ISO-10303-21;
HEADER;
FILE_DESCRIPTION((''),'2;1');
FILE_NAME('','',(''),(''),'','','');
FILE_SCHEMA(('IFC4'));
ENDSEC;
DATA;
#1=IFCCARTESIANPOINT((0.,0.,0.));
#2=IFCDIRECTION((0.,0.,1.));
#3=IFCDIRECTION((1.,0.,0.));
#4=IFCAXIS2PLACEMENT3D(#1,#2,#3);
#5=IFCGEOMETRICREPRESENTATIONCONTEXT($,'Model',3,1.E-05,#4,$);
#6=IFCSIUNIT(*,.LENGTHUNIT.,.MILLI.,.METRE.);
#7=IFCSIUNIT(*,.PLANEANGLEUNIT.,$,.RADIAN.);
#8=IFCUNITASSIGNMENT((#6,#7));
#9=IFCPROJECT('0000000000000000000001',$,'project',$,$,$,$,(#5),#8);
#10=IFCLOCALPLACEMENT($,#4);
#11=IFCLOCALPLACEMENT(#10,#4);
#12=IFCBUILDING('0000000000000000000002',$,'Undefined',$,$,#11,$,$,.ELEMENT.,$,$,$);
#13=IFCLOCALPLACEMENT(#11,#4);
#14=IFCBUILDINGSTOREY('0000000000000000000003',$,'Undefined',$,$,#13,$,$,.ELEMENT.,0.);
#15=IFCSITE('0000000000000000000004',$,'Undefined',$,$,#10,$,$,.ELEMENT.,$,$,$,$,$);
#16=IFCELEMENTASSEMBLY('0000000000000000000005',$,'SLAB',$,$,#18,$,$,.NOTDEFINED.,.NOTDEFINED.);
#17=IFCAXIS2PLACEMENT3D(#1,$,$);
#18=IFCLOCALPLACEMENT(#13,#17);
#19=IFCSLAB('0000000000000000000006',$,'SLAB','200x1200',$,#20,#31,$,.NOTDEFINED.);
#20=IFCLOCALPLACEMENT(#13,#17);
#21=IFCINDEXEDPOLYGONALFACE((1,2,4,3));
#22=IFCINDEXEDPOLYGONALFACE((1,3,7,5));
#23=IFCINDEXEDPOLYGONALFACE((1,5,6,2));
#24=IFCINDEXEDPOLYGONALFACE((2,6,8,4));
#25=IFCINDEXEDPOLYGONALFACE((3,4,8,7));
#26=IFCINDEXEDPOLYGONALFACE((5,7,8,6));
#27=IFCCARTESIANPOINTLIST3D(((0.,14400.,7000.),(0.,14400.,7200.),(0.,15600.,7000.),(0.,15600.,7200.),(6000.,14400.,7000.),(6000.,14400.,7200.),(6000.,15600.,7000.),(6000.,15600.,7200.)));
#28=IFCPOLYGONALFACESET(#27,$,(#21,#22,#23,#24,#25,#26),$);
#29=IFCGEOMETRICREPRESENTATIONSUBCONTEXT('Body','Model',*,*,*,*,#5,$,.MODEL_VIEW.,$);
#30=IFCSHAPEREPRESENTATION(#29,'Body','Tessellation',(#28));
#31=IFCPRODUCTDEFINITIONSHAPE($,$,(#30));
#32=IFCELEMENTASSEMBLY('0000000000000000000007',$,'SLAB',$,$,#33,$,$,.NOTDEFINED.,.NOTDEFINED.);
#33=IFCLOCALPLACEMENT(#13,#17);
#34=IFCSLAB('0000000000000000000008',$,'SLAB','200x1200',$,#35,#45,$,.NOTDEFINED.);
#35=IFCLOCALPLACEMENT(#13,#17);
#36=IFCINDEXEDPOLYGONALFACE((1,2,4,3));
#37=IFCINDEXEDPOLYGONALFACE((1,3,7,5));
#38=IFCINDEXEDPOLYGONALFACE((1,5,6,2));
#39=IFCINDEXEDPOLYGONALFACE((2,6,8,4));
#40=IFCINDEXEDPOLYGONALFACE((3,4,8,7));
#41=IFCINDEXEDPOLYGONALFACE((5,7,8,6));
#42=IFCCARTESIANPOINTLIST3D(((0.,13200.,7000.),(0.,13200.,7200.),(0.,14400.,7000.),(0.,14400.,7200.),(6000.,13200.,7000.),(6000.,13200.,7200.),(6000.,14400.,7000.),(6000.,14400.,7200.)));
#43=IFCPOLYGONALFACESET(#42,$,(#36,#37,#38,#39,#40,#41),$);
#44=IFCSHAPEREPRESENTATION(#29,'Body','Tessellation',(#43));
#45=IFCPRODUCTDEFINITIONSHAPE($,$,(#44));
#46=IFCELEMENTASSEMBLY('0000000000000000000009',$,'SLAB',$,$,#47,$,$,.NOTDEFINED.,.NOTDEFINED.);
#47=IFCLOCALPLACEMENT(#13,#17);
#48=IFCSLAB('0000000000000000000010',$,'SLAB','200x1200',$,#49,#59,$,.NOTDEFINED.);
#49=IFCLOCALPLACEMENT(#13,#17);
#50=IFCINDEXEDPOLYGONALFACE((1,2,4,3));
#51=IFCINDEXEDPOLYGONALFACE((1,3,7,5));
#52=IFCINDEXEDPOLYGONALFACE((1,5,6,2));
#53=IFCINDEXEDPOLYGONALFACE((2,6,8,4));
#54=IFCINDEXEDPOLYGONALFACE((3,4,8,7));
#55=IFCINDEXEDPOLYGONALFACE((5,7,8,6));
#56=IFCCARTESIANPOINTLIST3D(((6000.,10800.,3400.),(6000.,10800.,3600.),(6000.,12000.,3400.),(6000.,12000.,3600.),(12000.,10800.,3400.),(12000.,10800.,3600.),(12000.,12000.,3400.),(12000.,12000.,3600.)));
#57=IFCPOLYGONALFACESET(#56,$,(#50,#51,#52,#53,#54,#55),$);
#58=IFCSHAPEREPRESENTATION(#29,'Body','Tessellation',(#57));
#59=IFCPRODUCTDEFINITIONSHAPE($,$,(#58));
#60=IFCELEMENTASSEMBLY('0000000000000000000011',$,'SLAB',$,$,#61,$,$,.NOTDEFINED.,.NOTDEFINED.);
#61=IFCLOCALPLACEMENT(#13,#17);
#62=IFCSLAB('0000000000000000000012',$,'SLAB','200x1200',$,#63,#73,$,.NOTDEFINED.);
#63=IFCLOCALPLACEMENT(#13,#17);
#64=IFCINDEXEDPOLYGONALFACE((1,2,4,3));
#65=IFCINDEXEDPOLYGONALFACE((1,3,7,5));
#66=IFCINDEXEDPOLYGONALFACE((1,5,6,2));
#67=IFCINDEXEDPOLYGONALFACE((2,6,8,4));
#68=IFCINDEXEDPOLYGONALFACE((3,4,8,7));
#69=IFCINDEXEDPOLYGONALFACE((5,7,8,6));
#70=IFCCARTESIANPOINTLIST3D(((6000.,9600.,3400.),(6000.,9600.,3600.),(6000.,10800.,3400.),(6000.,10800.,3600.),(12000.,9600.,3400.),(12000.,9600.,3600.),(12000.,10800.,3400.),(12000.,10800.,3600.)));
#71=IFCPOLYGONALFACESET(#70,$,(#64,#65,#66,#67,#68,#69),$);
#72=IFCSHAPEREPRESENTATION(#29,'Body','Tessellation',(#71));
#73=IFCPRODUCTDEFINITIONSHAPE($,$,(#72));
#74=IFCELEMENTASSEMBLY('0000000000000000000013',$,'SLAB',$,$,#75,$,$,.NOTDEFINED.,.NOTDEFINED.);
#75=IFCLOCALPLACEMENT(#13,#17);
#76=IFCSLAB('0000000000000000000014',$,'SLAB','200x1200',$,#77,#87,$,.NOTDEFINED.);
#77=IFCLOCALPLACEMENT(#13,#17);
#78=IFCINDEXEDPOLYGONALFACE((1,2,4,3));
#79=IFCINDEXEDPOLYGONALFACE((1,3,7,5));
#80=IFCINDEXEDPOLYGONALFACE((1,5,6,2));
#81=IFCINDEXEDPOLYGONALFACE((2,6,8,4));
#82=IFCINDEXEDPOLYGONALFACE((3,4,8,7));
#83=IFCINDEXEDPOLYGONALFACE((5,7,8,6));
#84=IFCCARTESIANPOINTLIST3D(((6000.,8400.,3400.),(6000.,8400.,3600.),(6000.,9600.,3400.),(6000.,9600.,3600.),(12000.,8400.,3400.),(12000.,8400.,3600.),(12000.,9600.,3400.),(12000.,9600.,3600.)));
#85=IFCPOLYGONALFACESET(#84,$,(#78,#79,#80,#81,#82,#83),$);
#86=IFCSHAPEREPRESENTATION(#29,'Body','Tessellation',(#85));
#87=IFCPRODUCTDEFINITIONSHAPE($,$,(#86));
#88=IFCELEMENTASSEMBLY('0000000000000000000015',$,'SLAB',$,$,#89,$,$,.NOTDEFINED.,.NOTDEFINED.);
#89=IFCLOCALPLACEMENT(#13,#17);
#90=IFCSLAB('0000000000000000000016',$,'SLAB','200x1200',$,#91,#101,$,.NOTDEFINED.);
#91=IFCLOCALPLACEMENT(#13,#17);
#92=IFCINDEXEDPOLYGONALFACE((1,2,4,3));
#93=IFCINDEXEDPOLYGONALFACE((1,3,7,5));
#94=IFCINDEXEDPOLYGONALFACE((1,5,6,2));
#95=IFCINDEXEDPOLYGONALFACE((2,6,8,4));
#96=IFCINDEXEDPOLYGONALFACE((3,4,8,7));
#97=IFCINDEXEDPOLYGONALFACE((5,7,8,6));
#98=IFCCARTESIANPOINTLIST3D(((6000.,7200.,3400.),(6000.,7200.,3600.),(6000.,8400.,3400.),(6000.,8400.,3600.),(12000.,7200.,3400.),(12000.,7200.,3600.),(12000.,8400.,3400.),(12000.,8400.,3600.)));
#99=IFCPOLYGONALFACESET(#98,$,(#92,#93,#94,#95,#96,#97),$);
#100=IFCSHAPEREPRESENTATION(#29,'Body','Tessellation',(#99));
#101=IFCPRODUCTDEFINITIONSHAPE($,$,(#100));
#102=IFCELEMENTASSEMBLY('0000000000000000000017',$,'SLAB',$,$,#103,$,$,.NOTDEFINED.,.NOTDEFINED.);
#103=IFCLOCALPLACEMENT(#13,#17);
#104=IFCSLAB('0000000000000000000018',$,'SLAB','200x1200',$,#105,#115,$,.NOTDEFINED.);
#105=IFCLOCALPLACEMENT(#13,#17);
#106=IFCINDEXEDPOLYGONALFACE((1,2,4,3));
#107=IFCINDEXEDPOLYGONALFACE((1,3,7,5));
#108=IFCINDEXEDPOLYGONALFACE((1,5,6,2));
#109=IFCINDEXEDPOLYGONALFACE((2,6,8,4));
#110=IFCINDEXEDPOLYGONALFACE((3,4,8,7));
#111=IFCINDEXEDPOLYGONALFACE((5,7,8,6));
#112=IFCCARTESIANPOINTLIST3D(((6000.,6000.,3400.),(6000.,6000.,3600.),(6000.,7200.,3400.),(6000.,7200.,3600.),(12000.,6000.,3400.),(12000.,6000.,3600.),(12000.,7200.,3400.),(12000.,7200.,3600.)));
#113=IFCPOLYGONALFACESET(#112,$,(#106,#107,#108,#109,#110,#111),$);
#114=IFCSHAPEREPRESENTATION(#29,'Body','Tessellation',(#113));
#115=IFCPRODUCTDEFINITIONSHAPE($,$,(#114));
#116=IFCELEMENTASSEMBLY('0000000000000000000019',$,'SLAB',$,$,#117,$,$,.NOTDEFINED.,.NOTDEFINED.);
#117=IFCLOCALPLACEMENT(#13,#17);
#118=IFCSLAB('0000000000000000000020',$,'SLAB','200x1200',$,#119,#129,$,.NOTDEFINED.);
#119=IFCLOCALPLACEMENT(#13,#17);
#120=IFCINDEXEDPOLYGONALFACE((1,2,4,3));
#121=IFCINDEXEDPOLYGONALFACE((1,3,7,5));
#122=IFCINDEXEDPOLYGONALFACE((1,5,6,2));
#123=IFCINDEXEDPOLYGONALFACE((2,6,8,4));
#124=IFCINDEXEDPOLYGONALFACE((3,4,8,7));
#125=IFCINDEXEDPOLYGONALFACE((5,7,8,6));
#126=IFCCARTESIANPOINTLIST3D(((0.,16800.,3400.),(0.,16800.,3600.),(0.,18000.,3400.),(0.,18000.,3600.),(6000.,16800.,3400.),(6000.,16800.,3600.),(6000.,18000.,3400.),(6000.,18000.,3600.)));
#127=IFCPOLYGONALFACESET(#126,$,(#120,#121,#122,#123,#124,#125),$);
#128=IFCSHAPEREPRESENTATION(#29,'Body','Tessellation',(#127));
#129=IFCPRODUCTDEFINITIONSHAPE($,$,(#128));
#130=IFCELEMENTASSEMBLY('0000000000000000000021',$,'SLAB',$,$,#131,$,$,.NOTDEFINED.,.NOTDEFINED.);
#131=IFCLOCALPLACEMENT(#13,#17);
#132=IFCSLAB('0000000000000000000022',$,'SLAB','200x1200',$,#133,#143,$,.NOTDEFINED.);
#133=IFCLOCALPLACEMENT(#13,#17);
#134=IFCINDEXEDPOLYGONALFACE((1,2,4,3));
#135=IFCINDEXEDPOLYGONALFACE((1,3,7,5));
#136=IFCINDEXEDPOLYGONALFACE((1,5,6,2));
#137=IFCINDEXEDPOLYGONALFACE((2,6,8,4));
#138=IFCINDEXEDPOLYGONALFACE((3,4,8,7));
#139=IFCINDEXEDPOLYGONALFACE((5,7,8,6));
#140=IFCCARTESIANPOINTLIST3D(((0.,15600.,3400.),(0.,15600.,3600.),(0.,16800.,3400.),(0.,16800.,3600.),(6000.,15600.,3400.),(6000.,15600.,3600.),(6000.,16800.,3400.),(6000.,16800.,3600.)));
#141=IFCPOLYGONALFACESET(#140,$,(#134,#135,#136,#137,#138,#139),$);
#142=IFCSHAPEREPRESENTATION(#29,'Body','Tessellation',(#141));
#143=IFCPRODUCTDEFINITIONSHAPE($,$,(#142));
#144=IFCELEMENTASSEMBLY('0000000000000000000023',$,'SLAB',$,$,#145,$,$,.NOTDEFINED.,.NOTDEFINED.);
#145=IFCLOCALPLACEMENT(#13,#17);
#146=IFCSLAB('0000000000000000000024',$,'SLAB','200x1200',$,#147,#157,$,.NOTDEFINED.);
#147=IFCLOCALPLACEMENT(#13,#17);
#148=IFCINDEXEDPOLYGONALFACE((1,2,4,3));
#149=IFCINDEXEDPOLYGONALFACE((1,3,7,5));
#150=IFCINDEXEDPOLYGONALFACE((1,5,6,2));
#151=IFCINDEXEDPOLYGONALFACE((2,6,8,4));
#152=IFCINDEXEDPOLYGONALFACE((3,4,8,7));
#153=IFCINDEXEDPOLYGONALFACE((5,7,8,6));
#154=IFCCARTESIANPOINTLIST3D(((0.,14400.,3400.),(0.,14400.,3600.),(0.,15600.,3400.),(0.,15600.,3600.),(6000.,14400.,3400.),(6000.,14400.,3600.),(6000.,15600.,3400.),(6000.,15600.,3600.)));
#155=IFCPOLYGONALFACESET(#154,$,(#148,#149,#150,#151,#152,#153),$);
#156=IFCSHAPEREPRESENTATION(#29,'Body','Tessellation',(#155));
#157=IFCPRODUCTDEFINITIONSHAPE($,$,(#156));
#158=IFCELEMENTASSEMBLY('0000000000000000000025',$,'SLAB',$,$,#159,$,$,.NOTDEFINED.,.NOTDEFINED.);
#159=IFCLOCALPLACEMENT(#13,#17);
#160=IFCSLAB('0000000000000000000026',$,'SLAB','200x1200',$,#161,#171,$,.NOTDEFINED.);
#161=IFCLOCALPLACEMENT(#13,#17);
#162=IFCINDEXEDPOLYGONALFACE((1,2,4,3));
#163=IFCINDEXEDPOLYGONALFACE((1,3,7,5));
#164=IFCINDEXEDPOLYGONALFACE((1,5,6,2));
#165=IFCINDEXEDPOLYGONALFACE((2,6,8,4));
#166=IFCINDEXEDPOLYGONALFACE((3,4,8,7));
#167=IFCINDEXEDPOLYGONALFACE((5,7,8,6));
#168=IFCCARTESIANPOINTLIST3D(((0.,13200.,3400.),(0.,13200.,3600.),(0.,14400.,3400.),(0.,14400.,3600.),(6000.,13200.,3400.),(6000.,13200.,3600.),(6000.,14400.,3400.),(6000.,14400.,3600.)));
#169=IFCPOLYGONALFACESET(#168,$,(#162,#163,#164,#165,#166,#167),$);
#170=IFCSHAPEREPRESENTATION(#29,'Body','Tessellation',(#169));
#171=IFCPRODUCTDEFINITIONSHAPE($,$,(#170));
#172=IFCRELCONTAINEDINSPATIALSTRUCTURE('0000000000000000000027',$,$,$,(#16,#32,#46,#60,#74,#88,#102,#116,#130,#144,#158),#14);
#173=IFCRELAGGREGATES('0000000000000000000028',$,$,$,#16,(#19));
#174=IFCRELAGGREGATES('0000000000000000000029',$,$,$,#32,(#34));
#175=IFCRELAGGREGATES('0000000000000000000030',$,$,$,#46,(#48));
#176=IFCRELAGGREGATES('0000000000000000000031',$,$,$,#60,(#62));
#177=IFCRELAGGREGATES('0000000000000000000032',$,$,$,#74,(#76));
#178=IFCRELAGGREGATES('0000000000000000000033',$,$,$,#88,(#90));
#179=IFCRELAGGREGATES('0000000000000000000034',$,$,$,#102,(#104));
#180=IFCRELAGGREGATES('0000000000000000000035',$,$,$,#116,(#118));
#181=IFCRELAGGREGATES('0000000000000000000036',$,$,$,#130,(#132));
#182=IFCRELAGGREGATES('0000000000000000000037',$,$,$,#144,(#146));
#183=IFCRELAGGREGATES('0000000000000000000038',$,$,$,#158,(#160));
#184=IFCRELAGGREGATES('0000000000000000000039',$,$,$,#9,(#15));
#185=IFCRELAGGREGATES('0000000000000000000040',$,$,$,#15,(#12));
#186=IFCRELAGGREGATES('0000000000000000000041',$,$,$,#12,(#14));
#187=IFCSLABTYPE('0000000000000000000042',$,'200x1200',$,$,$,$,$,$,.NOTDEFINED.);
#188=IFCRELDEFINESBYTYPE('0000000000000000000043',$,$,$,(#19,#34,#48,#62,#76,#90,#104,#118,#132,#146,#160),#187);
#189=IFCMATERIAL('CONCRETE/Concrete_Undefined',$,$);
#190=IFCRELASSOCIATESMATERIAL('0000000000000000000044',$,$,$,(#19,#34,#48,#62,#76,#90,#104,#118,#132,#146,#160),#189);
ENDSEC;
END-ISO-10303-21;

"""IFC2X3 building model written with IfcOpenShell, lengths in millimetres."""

from ifc_helpers import new_model, si_unit, frame, origin_with_axes, place, context, subcontext, project, spatial, polyline, outline, extrude, material, type_object, element, aggregate, save


model = new_model("IFC2X3")

# Units and contexts
model_context = context("Model", 3, precision=1e-05, world=origin_with_axes())
body_context = subcontext(model_context, "Body", "Model", "MODEL_VIEW")
ifc_project = project(units=[si_unit("LENGTHUNIT", "METRE", prefix="MILLI"), si_unit("PLANEANGLEUNIT", "RADIAN")], contexts=[model_context])

# Site, building, storey
site_placement = place(None, origin_with_axes())
site = spatial("IfcSite", under=ifc_project, at=site_placement, Name="Undefined", CompositionType="ELEMENT")
building_placement = place(site_placement, origin_with_axes())
building = spatial("IfcBuilding", under=site, at=building_placement, Name="Undefined", CompositionType="ELEMENT")
storey_placement = place(building_placement, origin_with_axes())
storey = spatial("IfcBuildingStorey", under=building, at=storey_placement, Name="Undefined", CompositionType="ELEMENT", Elevation=0.0)

# Shared definitions
ifc_material_1 = material(Name="CONCRETE/Concrete_Undefined")

# Element assemblies, slabs
slab_type = type_object("IfcSlabType", Name="200x1200", PredefinedType="NOTDEFINED")
assembly_1_placement = place(storey_placement, origin_with_axes())
assembly_1 = element("IfcElementAssembly", 1, at=assembly_1_placement, inside=storey, Name="SLAB", AssemblyPlace="NOTDEFINED", PredefinedType="NOTDEFINED")
slab_1_placement = place(assembly_1_placement, frame((6000.0, 14400.0, 7100.0), z_axis=(0.0, 0.0, 1.0), x_axis=(0.0, 1.0, 0.0)))
slab_1 = element("IfcSlab", 2, at=slab_1_placement, type_object=slab_type, material=ifc_material_1, Name="SLAB", Description="200x1200", PredefinedType="NOTDEFINED", context=body_context, shape_type="SweptSolid", body=[
    extrude(outline(polyline([(0.0, 0.0), (1200.0, 0.0), (1200.0, 6000.0), (0.0, 6000.0), (0.0, 0.0)])), frame((0.0, 0.0, -100.0), z_axis=(0.0, 0.0, 1.0), x_axis=(1.0, 0.0, 0.0)), (0.0, 0.0, 1.0), 200.0),
])
aggregate(assembly_1, [slab_1])
assembly_2_placement = place(storey_placement, origin_with_axes())
assembly_2 = element("IfcElementAssembly", 3, at=assembly_2_placement, inside=storey, Name="SLAB", AssemblyPlace="NOTDEFINED", PredefinedType="NOTDEFINED")
slab_2_placement = place(assembly_2_placement, frame((6000.0, 13200.0, 7100.0), z_axis=(0.0, 0.0, 1.0), x_axis=(0.0, 1.0, 0.0)))
slab_2 = element("IfcSlab", 4, at=slab_2_placement, type_object=slab_type, material=ifc_material_1, Name="SLAB", Description="200x1200", PredefinedType="NOTDEFINED", context=body_context, shape_type="SweptSolid", body=[
    extrude(outline(polyline([(0.0, 0.0), (1200.0, 0.0), (1200.0, 6000.0), (0.0, 6000.0), (0.0, 0.0)])), frame((0.0, 0.0, -100.0), z_axis=(0.0, 0.0, 1.0), x_axis=(1.0, 0.0, 0.0)), (0.0, 0.0, 1.0), 200.0),
])
aggregate(assembly_2, [slab_2])
assembly_3_placement = place(storey_placement, origin_with_axes())
assembly_3 = element("IfcElementAssembly", 5, at=assembly_3_placement, inside=storey, Name="SLAB", AssemblyPlace="NOTDEFINED", PredefinedType="NOTDEFINED")
slab_3_placement = place(assembly_3_placement, frame((12000.0, 10800.0, 3500.0), z_axis=(0.0, 0.0, 1.0), x_axis=(0.0, 1.0, 0.0)))
slab_3 = element("IfcSlab", 6, at=slab_3_placement, type_object=slab_type, material=ifc_material_1, Name="SLAB", Description="200x1200", PredefinedType="NOTDEFINED", context=body_context, shape_type="SweptSolid", body=[
    extrude(outline(polyline([(0.0, 0.0), (1200.0, 0.0), (1200.0, 6000.0), (0.0, 6000.0), (0.0, 0.0)])), frame((0.0, 0.0, -100.0), z_axis=(0.0, 0.0, 1.0), x_axis=(1.0, 0.0, 0.0)), (0.0, 0.0, 1.0), 200.0),
])
aggregate(assembly_3, [slab_3])
assembly_4_placement = place(storey_placement, origin_with_axes())
assembly_4 = element("IfcElementAssembly", 7, at=assembly_4_placement, inside=storey, Name="SLAB", AssemblyPlace="NOTDEFINED", PredefinedType="NOTDEFINED")
slab_4_placement = place(assembly_4_placement, frame((12000.0, 9600.0, 3500.0), z_axis=(0.0, 0.0, 1.0), x_axis=(0.0, 1.0, 0.0)))
slab_4 = element("IfcSlab", 8, at=slab_4_placement, type_object=slab_type, material=ifc_material_1, Name="SLAB", Description="200x1200", PredefinedType="NOTDEFINED", context=body_context, shape_type="SweptSolid", body=[
    extrude(outline(polyline([(0.0, 0.0), (1200.0, 0.0), (1200.0, 6000.0), (0.0, 6000.0), (0.0, 0.0)])), frame((0.0, 0.0, -100.0), z_axis=(0.0, 0.0, 1.0), x_axis=(1.0, 0.0, 0.0)), (0.0, 0.0, 1.0), 200.0),
])
aggregate(assembly_4, [slab_4])
assembly_5_placement = place(storey_placement, origin_with_axes())
assembly_5 = element("IfcElementAssembly", 9, at=assembly_5_placement, inside=storey, Name="SLAB", AssemblyPlace="NOTDEFINED", PredefinedType="NOTDEFINED")
slab_5_placement = place(assembly_5_placement, frame((12000.0, 8400.0, 3500.0), z_axis=(0.0, 0.0, 1.0), x_axis=(0.0, 1.0, 0.0)))
slab_5 = element("IfcSlab", 10, at=slab_5_placement, type_object=slab_type, material=ifc_material_1, Name="SLAB", Description="200x1200", PredefinedType="NOTDEFINED", context=body_context, shape_type="SweptSolid", body=[
    extrude(outline(polyline([(0.0, 0.0), (1200.0, 0.0), (1200.0, 6000.0), (0.0, 6000.0), (0.0, 0.0)])), frame((0.0, 0.0, -100.0), z_axis=(0.0, 0.0, 1.0), x_axis=(1.0, 0.0, 0.0)), (0.0, 0.0, 1.0), 200.0),
])
aggregate(assembly_5, [slab_5])
assembly_6_placement = place(storey_placement, origin_with_axes())
assembly_6 = element("IfcElementAssembly", 11, at=assembly_6_placement, inside=storey, Name="SLAB", AssemblyPlace="NOTDEFINED", PredefinedType="NOTDEFINED")
slab_6_placement = place(assembly_6_placement, frame((12000.0, 7200.0, 3500.0), z_axis=(0.0, 0.0, 1.0), x_axis=(0.0, 1.0, 0.0)))
slab_6 = element("IfcSlab", 12, at=slab_6_placement, type_object=slab_type, material=ifc_material_1, Name="SLAB", Description="200x1200", PredefinedType="NOTDEFINED", context=body_context, shape_type="SweptSolid", body=[
    extrude(outline(polyline([(0.0, 0.0), (1200.0, 0.0), (1200.0, 6000.0), (0.0, 6000.0), (0.0, 0.0)])), frame((0.0, 0.0, -100.0), z_axis=(0.0, 0.0, 1.0), x_axis=(1.0, 0.0, 0.0)), (0.0, 0.0, 1.0), 200.0),
])
aggregate(assembly_6, [slab_6])
assembly_7_placement = place(storey_placement, origin_with_axes())
assembly_7 = element("IfcElementAssembly", 13, at=assembly_7_placement, inside=storey, Name="SLAB", AssemblyPlace="NOTDEFINED", PredefinedType="NOTDEFINED")
slab_7_placement = place(assembly_7_placement, frame((12000.0, 6000.0, 3500.0), z_axis=(0.0, 0.0, 1.0), x_axis=(0.0, 1.0, 0.0)))
slab_7 = element("IfcSlab", 14, at=slab_7_placement, type_object=slab_type, material=ifc_material_1, Name="SLAB", Description="200x1200", PredefinedType="NOTDEFINED", context=body_context, shape_type="SweptSolid", body=[
    extrude(outline(polyline([(0.0, 0.0), (1200.0, 0.0), (1200.0, 6000.0), (0.0, 6000.0), (0.0, 0.0)])), frame((0.0, 0.0, -100.0), z_axis=(0.0, 0.0, 1.0), x_axis=(1.0, 0.0, 0.0)), (0.0, 0.0, 1.0), 200.0),
])
aggregate(assembly_7, [slab_7])
assembly_8_placement = place(storey_placement, origin_with_axes())
assembly_8 = element("IfcElementAssembly", 15, at=assembly_8_placement, inside=storey, Name="SLAB", AssemblyPlace="NOTDEFINED", PredefinedType="NOTDEFINED")
slab_8_placement = place(assembly_8_placement, frame((6000.0, 16800.0, 3500.0), z_axis=(0.0, 0.0, 1.0), x_axis=(0.0, 1.0, 0.0)))
slab_8 = element("IfcSlab", 16, at=slab_8_placement, type_object=slab_type, material=ifc_material_1, Name="SLAB", Description="200x1200", PredefinedType="NOTDEFINED", context=body_context, shape_type="SweptSolid", body=[
    extrude(outline(polyline([(0.0, 0.0), (1200.0, 0.0), (1200.0, 6000.0), (0.0, 6000.0), (0.0, 0.0)])), frame((0.0, 0.0, -100.0), z_axis=(0.0, 0.0, 1.0), x_axis=(1.0, 0.0, 0.0)), (0.0, 0.0, 1.0), 200.0),
])
aggregate(assembly_8, [slab_8])
assembly_9_placement = place(storey_placement, origin_with_axes())
assembly_9 = element("IfcElementAssembly", 17, at=assembly_9_placement, inside=storey, Name="SLAB", AssemblyPlace="NOTDEFINED", PredefinedType="NOTDEFINED")
slab_9_placement = place(assembly_9_placement, frame((6000.0, 15600.0, 3500.0), z_axis=(0.0, 0.0, 1.0), x_axis=(0.0, 1.0, 0.0)))
slab_9 = element("IfcSlab", 18, at=slab_9_placement, type_object=slab_type, material=ifc_material_1, Name="SLAB", Description="200x1200", PredefinedType="NOTDEFINED", context=body_context, shape_type="SweptSolid", body=[
    extrude(outline(polyline([(0.0, 0.0), (1200.0, 0.0), (1200.0, 6000.0), (0.0, 6000.0), (0.0, 0.0)])), frame((0.0, 0.0, -100.0), z_axis=(0.0, 0.0, 1.0), x_axis=(1.0, 0.0, 0.0)), (0.0, 0.0, 1.0), 200.0),
])
aggregate(assembly_9, [slab_9])
assembly_10_placement = place(storey_placement, origin_with_axes())
assembly_10 = element("IfcElementAssembly", 19, at=assembly_10_placement, inside=storey, Name="SLAB", AssemblyPlace="NOTDEFINED", PredefinedType="NOTDEFINED")
slab_10_placement = place(assembly_10_placement, frame((6000.0, 14400.0, 3500.0), z_axis=(0.0, 0.0, 1.0), x_axis=(0.0, 1.0, 0.0)))
slab_10 = element("IfcSlab", 20, at=slab_10_placement, type_object=slab_type, material=ifc_material_1, Name="SLAB", Description="200x1200", PredefinedType="NOTDEFINED", context=body_context, shape_type="SweptSolid", body=[
    extrude(outline(polyline([(0.0, 0.0), (1200.0, 0.0), (1200.0, 6000.0), (0.0, 6000.0), (0.0, 0.0)])), frame((0.0, 0.0, -100.0), z_axis=(0.0, 0.0, 1.0), x_axis=(1.0, 0.0, 0.0)), (0.0, 0.0, 1.0), 200.0),
])
aggregate(assembly_10, [slab_10])
assembly_11_placement = place(storey_placement, origin_with_axes())
assembly_11 = element("IfcElementAssembly", 21, at=assembly_11_placement, inside=storey, Name="SLAB", AssemblyPlace="NOTDEFINED", PredefinedType="NOTDEFINED")
slab_11_placement = place(assembly_11_placement, frame((6000.0, 13200.0, 3500.0), z_axis=(0.0, 0.0, 1.0), x_axis=(0.0, 1.0, 0.0)))
slab_11 = element("IfcSlab", 22, at=slab_11_placement, type_object=slab_type, material=ifc_material_1, Name="SLAB", Description="200x1200", PredefinedType="NOTDEFINED", context=body_context, shape_type="SweptSolid", body=[
    extrude(outline(polyline([(0.0, 0.0), (1200.0, 0.0), (1200.0, 6000.0), (0.0, 6000.0), (0.0, 0.0)])), frame((0.0, 0.0, -100.0), z_axis=(0.0, 0.0, 1.0), x_axis=(1.0, 0.0, 0.0)), (0.0, 0.0, 1.0), 200.0),
])
aggregate(assembly_11, [slab_11])

save(model, "model.ifc")
